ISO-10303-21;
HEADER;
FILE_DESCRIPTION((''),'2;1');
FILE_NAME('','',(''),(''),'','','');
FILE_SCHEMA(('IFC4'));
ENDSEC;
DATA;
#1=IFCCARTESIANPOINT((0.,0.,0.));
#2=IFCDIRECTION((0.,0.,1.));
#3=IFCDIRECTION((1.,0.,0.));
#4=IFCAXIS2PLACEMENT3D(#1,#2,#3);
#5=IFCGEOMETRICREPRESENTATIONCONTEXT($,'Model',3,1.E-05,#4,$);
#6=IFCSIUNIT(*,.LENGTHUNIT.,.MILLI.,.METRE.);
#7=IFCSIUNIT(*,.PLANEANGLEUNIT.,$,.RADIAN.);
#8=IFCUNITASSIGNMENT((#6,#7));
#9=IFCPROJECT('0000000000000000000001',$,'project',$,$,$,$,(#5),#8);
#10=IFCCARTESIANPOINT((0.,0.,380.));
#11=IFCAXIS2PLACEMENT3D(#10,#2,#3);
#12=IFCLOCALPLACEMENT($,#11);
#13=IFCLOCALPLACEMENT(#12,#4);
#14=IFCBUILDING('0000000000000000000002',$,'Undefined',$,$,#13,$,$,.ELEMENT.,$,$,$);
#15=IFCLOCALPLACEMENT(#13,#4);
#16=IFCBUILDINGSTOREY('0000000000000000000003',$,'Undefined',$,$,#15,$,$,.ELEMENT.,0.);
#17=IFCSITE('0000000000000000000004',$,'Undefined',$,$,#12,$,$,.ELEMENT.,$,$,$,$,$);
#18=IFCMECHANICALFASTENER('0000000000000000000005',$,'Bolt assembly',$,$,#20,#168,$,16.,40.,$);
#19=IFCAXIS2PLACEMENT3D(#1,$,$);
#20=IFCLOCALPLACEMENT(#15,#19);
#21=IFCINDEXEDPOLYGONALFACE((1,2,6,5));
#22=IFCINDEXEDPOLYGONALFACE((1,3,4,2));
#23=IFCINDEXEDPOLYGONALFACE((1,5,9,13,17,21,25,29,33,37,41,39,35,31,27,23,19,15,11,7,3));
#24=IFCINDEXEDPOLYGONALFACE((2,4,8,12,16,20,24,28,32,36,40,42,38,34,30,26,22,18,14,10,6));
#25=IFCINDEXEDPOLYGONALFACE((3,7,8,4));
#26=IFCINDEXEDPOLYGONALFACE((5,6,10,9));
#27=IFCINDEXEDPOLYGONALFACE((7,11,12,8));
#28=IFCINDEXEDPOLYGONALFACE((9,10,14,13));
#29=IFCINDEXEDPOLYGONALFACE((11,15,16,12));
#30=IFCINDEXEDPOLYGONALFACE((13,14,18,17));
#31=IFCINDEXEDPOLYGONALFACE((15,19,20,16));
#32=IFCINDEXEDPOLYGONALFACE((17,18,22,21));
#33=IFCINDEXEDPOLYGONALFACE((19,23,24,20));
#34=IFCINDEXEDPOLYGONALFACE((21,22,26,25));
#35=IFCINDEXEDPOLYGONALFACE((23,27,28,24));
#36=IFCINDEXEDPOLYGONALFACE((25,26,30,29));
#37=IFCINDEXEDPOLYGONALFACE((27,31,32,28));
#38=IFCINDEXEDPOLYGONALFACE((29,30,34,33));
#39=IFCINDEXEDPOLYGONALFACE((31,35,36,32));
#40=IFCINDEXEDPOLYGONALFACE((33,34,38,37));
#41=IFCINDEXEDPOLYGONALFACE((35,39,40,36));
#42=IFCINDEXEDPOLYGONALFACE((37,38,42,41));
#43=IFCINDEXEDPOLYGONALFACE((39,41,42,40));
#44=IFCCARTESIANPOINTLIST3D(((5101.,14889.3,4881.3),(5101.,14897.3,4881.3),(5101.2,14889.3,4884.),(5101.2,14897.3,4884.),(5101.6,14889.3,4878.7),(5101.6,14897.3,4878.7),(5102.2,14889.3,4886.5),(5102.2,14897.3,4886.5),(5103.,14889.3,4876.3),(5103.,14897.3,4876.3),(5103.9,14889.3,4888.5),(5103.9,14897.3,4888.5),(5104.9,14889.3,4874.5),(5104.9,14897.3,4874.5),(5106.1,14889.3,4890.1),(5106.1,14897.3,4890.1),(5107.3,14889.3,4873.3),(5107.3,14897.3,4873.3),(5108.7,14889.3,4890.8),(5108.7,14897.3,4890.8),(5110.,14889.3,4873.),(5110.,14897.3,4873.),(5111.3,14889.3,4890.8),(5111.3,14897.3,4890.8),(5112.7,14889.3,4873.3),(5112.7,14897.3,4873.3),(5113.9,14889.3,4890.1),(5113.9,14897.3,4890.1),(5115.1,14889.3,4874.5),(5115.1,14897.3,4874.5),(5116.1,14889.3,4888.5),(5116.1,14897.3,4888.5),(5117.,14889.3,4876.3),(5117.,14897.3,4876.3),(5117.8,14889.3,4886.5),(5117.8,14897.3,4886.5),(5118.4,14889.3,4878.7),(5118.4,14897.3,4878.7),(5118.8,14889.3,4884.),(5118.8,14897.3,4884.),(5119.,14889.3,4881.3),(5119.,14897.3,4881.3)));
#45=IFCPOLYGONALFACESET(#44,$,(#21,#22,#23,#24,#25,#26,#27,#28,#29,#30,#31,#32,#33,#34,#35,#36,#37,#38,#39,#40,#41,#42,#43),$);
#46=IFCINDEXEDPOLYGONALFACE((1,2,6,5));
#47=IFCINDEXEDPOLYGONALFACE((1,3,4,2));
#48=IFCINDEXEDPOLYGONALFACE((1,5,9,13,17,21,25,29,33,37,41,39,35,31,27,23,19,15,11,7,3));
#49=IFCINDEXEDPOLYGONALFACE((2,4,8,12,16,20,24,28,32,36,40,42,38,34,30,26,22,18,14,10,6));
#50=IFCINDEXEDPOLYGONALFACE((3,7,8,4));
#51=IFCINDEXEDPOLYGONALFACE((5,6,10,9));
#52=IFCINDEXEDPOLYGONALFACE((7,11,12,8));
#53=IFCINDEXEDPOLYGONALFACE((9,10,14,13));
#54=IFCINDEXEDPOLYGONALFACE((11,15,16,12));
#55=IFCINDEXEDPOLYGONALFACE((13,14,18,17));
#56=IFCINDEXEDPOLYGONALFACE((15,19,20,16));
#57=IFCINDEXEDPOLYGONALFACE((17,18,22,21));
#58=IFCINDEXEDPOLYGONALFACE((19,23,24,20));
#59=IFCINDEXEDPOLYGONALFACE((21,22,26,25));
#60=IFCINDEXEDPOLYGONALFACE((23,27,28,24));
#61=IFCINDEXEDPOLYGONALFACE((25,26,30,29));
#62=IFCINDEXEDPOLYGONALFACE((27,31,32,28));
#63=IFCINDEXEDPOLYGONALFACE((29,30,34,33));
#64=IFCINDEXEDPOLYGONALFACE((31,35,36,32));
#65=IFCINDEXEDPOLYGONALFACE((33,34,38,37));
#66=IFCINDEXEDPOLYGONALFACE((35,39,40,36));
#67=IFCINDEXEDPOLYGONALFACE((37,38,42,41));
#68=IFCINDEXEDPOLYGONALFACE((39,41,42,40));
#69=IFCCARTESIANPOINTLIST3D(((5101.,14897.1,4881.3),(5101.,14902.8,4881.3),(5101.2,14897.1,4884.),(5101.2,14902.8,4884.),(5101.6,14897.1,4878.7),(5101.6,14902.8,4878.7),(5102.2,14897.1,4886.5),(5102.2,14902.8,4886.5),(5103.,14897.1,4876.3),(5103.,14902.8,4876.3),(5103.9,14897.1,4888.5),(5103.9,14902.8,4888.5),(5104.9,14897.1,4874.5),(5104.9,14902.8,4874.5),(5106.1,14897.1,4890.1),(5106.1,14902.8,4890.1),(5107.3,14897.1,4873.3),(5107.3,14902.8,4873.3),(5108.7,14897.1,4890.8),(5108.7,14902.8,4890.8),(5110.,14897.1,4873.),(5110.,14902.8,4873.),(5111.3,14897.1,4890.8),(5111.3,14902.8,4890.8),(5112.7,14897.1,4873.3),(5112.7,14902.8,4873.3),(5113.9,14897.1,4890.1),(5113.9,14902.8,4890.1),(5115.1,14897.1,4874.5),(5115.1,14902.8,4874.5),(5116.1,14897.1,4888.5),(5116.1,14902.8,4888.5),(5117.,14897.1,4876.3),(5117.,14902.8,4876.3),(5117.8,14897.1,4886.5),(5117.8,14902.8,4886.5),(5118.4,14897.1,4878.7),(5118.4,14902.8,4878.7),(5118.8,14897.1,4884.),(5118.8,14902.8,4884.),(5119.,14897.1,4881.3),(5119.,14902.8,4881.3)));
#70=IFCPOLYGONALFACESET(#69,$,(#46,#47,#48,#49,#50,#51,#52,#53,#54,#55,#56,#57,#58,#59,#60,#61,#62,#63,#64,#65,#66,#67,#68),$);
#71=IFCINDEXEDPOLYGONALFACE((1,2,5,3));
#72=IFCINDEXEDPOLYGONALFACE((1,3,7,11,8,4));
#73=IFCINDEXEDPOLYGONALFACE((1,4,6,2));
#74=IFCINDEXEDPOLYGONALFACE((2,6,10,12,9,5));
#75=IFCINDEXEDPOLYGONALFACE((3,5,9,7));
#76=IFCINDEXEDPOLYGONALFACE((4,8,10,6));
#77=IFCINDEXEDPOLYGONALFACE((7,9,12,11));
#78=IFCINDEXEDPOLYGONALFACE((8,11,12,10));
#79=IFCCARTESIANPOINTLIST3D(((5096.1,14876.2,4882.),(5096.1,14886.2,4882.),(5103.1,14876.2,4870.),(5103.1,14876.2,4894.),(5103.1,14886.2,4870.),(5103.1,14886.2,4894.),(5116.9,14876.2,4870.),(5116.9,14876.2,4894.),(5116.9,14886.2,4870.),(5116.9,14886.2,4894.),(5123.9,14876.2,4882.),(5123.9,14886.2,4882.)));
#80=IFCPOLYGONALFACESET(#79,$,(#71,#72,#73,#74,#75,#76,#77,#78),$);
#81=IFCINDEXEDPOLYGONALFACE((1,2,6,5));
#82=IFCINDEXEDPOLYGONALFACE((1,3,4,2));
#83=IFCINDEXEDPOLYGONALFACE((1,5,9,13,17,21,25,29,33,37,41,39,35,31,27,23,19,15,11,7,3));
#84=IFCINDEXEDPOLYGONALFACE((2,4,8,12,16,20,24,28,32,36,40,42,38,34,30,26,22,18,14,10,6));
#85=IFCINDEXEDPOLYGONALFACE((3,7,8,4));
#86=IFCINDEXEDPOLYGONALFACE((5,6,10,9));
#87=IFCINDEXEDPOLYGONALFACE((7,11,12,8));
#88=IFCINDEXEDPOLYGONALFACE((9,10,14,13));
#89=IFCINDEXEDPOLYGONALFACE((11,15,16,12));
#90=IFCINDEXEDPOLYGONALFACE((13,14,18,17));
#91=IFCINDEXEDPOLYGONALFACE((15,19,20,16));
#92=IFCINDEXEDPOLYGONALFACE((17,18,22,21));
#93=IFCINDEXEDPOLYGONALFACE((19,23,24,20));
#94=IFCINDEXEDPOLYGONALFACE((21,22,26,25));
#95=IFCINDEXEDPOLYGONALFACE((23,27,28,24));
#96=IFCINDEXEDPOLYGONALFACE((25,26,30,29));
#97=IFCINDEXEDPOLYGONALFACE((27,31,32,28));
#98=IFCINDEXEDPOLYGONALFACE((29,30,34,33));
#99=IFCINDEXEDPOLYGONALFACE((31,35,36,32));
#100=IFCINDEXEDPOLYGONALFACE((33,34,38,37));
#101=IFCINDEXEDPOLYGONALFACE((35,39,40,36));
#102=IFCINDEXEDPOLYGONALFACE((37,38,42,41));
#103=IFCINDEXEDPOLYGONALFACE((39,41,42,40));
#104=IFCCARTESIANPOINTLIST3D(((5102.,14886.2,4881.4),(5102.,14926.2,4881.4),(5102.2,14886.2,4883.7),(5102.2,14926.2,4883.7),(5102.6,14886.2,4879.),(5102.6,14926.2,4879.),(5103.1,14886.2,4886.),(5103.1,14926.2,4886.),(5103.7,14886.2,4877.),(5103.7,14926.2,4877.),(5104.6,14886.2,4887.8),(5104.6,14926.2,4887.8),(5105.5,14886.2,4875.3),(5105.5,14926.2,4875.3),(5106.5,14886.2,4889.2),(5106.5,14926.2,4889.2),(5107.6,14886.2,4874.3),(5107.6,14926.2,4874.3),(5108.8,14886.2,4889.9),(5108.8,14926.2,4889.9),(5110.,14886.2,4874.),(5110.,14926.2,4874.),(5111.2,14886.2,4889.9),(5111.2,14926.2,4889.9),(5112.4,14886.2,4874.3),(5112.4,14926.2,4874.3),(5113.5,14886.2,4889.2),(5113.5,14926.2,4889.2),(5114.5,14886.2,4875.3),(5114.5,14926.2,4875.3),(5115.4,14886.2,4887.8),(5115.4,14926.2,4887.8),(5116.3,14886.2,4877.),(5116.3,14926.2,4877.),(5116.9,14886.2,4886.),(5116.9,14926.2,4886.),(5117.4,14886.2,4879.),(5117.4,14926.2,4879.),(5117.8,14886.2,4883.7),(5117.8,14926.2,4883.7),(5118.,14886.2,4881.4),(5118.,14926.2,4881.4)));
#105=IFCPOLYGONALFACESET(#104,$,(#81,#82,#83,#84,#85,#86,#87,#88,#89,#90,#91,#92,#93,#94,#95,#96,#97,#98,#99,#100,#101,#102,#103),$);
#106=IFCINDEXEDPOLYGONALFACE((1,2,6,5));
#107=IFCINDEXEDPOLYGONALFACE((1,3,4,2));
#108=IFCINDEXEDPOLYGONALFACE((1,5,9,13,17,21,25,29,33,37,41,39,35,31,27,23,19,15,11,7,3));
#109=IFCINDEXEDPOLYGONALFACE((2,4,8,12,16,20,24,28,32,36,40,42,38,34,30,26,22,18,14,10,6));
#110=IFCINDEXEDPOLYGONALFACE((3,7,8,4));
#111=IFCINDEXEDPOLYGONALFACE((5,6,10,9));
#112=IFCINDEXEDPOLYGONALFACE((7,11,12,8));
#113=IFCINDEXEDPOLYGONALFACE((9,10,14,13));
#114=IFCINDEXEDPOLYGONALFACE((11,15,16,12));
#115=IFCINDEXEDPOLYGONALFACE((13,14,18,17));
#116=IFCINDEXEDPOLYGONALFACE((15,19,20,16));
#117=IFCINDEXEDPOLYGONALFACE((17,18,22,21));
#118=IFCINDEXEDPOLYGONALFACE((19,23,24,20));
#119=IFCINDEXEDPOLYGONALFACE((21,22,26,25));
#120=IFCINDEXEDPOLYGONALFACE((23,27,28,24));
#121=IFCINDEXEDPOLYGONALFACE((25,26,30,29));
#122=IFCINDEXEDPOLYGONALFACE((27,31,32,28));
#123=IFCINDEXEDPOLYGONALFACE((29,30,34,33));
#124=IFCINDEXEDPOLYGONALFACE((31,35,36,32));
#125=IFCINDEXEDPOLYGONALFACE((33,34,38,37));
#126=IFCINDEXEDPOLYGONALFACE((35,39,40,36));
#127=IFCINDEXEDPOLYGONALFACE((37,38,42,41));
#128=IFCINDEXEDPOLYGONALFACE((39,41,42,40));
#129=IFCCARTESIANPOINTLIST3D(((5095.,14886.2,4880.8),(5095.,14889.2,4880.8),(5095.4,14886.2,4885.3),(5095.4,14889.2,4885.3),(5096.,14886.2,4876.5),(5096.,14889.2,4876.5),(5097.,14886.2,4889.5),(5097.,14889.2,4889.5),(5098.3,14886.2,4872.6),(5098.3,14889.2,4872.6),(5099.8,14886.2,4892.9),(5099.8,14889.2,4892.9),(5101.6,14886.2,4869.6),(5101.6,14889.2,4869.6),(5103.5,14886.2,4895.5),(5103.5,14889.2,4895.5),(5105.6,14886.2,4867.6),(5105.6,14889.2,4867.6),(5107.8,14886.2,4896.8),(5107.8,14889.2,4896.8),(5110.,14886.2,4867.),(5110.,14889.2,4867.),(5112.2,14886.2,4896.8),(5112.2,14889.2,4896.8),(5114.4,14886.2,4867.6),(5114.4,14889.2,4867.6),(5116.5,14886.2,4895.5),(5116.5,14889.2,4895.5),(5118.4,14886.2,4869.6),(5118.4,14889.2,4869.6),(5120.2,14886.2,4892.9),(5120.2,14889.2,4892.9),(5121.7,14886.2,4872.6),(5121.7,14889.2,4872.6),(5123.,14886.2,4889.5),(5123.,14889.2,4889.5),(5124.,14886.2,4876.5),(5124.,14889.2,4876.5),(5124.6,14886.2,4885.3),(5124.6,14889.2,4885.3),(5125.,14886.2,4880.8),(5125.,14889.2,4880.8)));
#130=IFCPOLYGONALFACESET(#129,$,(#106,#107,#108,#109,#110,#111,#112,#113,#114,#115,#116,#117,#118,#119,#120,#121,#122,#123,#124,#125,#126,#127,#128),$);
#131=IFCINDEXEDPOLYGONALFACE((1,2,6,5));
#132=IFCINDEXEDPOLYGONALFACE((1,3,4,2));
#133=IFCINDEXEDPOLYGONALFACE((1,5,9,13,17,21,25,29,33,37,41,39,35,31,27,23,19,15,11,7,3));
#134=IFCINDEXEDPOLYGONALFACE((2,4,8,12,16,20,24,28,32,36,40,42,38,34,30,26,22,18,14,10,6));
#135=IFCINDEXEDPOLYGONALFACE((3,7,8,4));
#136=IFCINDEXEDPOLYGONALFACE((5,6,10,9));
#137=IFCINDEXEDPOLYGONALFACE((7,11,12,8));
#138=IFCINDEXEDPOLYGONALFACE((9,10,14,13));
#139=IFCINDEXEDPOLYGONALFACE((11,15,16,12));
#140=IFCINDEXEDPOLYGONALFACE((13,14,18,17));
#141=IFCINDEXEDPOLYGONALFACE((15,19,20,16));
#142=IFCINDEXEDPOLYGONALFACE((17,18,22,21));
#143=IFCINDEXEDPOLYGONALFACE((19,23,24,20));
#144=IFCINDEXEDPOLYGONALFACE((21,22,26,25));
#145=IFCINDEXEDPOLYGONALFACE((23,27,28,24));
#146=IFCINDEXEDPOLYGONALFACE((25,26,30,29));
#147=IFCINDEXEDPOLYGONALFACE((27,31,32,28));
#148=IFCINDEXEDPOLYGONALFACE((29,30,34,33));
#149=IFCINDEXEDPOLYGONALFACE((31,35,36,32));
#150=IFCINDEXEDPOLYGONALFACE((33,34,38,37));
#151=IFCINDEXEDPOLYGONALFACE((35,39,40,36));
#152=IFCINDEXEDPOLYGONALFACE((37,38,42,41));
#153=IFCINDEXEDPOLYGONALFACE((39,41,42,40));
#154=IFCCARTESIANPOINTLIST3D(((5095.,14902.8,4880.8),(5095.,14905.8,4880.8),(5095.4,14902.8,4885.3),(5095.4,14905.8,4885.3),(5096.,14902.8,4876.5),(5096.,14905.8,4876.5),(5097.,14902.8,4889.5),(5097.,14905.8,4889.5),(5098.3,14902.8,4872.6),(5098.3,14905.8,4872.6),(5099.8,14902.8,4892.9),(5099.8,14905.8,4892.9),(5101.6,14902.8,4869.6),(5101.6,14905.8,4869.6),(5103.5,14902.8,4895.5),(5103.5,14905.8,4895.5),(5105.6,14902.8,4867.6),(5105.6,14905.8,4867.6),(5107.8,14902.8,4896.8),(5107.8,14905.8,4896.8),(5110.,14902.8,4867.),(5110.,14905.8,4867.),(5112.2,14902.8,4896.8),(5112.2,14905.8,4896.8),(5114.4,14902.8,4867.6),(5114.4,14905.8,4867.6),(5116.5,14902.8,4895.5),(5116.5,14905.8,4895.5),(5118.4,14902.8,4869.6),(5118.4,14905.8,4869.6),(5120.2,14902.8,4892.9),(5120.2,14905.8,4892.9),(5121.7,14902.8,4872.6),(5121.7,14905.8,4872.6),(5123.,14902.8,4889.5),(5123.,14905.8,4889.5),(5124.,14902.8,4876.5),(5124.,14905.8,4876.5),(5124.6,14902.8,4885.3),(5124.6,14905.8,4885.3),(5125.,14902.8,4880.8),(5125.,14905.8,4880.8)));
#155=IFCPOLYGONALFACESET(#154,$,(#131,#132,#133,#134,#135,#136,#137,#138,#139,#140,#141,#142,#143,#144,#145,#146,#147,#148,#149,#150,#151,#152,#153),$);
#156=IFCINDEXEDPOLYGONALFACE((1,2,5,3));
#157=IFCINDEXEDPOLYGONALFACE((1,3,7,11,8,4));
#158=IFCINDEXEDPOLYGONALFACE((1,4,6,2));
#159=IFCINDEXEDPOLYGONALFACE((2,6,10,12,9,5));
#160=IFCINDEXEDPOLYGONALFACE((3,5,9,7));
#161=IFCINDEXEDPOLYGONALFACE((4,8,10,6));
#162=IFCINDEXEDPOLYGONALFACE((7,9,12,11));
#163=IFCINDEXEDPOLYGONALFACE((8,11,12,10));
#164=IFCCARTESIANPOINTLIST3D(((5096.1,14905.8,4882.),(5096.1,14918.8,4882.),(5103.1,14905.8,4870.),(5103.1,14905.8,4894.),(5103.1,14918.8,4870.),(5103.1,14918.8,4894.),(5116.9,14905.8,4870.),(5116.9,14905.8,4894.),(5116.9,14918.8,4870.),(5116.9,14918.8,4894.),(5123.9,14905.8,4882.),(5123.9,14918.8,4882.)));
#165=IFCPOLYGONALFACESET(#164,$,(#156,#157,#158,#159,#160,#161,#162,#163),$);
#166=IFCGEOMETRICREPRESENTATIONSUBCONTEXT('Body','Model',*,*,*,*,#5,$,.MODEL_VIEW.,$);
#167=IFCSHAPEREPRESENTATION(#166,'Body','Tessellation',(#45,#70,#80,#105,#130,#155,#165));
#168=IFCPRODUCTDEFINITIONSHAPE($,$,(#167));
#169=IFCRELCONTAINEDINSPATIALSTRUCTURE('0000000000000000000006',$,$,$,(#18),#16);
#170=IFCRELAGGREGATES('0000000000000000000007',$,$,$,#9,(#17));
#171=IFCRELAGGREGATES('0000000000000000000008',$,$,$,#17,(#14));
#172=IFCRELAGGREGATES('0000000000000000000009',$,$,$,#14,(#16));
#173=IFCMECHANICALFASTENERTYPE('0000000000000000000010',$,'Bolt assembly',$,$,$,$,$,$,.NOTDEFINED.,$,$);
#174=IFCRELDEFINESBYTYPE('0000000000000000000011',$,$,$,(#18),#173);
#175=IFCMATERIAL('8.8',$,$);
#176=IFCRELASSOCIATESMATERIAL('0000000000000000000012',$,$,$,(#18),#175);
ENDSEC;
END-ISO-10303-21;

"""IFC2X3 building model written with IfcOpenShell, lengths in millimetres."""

from ifc_helpers import new_model, si_unit, frame, origin_with_axes, origin_2d_with_axis, place, context, subcontext, project, spatial, polyline, circle, outline, extrude, source, transform, mapped, material, type_object, element, save


model = new_model("IFC2X3")

# Units and contexts
model_context = context("Model", 3, precision=1e-05, world=origin_with_axes())
body_context = subcontext(model_context, "Body", "Model", "MODEL_VIEW")
ifc_project = project(units=[si_unit("LENGTHUNIT", "METRE", prefix="MILLI"), si_unit("PLANEANGLEUNIT", "RADIAN")], contexts=[model_context])

# Site, building, storey
site_placement = place(None, frame((0.0, 0.0, 380.0), z_axis=(0.0, 0.0, 1.0), x_axis=(1.0, 0.0, 0.0)))
site = spatial("IfcSite", under=ifc_project, at=site_placement, Name="Undefined", CompositionType="ELEMENT")
building_placement = place(site_placement, origin_with_axes())
building = spatial("IfcBuilding", under=site, at=building_placement, Name="Undefined", CompositionType="ELEMENT")
storey_placement = place(building_placement, origin_with_axes())
storey = spatial("IfcBuildingStorey", under=building, at=storey_placement, Name="Undefined", CompositionType="ELEMENT", Elevation=0.0)

# Mechanical fastener
ifc_material_1 = material(Name="8.8")
mechanical_fastener_type = type_object("IfcMechanicalFastenerType", Name="Bolt assembly")
shared_shape_1 = source(origin_with_axes(), body_context, "Body", "SweptSolid", [
    extrude(circle(Radius=9.0, at=origin_2d_with_axis()), frame((0.0, -7.9, 0.0), z_axis=(0.0, 1.0, 0.0), x_axis=(1.0, 0.0, 0.0)), (0.0, 0.0, 1.0), 8.0),
    extrude(circle(Radius=9.0, at=origin_2d_with_axis()), frame((0.0, -0.1, 0.0), z_axis=(0.0, 1.0, 0.0), x_axis=(1.0, 0.0, 0.0)), (0.0, 0.0, 1.0), 5.7),
    extrude(outline(polyline([(12.0, -6.9), (12.0, 6.9), (0.0, 13.9), (-12.0, 6.9), (-12.0, -6.9), (0.0, -13.9), (12.0, -6.9)])), frame((0.0, -21.0, 0.0), z_axis=(0.0, 1.0, 0.0), x_axis=(1.0, 0.0, 0.0)), (0.0, 0.0, 1.0), 10.0),
    extrude(circle(Radius=8.0, at=origin_2d_with_axis()), frame((0.0, -11.0, 0.0), z_axis=(0.0, 1.0, 0.0), x_axis=(1.0, 0.0, 0.0)), (0.0, 0.0, 1.0), 40.0),
    extrude(circle(Radius=15.0, at=origin_2d_with_axis()), frame((0.0, -11.0, 0.0), z_axis=(0.0, 1.0, 0.0), x_axis=(1.0, 0.0, 0.0)), (0.0, 0.0, 1.0), 3.0),
    extrude(circle(Radius=15.0, at=origin_2d_with_axis()), frame((0.0, 5.6, 0.0), z_axis=(0.0, 1.0, 0.0), x_axis=(1.0, 0.0, 0.0)), (0.0, 0.0, 1.0), 3.0),
    extrude(outline(polyline([(12.0, -6.9), (12.0, 6.9), (0.0, 13.9), (-12.0, 6.9), (-12.0, -6.9), (0.0, -13.9), (12.0, -6.9)])), frame((0.0, 8.6, 0.0), z_axis=(0.0, 1.0, 0.0), x_axis=(1.0, 0.0, 0.0)), (0.0, 0.0, 1.0), 13.0),
])
mechanical_fastener_1_placement = place(storey_placement, frame((5072.5, 14897.2, 4962.0), z_axis=(1.0, 0.0, 0.0), x_axis=(0.0, 0.0, -1.0)))
element("IfcMechanicalFastener", 1, at=mechanical_fastener_1_placement, inside=storey, type_object=mechanical_fastener_type, material=ifc_material_1, Name="Bolt assembly", NominalDiameter=16.0, NominalLength=40.0, context=body_context, shape_type="MappedRepresentation", body=[
    mapped(shared_shape_1, transform((80.0, 0.0, 37.5))),
])

save(model, "model.ifc")
